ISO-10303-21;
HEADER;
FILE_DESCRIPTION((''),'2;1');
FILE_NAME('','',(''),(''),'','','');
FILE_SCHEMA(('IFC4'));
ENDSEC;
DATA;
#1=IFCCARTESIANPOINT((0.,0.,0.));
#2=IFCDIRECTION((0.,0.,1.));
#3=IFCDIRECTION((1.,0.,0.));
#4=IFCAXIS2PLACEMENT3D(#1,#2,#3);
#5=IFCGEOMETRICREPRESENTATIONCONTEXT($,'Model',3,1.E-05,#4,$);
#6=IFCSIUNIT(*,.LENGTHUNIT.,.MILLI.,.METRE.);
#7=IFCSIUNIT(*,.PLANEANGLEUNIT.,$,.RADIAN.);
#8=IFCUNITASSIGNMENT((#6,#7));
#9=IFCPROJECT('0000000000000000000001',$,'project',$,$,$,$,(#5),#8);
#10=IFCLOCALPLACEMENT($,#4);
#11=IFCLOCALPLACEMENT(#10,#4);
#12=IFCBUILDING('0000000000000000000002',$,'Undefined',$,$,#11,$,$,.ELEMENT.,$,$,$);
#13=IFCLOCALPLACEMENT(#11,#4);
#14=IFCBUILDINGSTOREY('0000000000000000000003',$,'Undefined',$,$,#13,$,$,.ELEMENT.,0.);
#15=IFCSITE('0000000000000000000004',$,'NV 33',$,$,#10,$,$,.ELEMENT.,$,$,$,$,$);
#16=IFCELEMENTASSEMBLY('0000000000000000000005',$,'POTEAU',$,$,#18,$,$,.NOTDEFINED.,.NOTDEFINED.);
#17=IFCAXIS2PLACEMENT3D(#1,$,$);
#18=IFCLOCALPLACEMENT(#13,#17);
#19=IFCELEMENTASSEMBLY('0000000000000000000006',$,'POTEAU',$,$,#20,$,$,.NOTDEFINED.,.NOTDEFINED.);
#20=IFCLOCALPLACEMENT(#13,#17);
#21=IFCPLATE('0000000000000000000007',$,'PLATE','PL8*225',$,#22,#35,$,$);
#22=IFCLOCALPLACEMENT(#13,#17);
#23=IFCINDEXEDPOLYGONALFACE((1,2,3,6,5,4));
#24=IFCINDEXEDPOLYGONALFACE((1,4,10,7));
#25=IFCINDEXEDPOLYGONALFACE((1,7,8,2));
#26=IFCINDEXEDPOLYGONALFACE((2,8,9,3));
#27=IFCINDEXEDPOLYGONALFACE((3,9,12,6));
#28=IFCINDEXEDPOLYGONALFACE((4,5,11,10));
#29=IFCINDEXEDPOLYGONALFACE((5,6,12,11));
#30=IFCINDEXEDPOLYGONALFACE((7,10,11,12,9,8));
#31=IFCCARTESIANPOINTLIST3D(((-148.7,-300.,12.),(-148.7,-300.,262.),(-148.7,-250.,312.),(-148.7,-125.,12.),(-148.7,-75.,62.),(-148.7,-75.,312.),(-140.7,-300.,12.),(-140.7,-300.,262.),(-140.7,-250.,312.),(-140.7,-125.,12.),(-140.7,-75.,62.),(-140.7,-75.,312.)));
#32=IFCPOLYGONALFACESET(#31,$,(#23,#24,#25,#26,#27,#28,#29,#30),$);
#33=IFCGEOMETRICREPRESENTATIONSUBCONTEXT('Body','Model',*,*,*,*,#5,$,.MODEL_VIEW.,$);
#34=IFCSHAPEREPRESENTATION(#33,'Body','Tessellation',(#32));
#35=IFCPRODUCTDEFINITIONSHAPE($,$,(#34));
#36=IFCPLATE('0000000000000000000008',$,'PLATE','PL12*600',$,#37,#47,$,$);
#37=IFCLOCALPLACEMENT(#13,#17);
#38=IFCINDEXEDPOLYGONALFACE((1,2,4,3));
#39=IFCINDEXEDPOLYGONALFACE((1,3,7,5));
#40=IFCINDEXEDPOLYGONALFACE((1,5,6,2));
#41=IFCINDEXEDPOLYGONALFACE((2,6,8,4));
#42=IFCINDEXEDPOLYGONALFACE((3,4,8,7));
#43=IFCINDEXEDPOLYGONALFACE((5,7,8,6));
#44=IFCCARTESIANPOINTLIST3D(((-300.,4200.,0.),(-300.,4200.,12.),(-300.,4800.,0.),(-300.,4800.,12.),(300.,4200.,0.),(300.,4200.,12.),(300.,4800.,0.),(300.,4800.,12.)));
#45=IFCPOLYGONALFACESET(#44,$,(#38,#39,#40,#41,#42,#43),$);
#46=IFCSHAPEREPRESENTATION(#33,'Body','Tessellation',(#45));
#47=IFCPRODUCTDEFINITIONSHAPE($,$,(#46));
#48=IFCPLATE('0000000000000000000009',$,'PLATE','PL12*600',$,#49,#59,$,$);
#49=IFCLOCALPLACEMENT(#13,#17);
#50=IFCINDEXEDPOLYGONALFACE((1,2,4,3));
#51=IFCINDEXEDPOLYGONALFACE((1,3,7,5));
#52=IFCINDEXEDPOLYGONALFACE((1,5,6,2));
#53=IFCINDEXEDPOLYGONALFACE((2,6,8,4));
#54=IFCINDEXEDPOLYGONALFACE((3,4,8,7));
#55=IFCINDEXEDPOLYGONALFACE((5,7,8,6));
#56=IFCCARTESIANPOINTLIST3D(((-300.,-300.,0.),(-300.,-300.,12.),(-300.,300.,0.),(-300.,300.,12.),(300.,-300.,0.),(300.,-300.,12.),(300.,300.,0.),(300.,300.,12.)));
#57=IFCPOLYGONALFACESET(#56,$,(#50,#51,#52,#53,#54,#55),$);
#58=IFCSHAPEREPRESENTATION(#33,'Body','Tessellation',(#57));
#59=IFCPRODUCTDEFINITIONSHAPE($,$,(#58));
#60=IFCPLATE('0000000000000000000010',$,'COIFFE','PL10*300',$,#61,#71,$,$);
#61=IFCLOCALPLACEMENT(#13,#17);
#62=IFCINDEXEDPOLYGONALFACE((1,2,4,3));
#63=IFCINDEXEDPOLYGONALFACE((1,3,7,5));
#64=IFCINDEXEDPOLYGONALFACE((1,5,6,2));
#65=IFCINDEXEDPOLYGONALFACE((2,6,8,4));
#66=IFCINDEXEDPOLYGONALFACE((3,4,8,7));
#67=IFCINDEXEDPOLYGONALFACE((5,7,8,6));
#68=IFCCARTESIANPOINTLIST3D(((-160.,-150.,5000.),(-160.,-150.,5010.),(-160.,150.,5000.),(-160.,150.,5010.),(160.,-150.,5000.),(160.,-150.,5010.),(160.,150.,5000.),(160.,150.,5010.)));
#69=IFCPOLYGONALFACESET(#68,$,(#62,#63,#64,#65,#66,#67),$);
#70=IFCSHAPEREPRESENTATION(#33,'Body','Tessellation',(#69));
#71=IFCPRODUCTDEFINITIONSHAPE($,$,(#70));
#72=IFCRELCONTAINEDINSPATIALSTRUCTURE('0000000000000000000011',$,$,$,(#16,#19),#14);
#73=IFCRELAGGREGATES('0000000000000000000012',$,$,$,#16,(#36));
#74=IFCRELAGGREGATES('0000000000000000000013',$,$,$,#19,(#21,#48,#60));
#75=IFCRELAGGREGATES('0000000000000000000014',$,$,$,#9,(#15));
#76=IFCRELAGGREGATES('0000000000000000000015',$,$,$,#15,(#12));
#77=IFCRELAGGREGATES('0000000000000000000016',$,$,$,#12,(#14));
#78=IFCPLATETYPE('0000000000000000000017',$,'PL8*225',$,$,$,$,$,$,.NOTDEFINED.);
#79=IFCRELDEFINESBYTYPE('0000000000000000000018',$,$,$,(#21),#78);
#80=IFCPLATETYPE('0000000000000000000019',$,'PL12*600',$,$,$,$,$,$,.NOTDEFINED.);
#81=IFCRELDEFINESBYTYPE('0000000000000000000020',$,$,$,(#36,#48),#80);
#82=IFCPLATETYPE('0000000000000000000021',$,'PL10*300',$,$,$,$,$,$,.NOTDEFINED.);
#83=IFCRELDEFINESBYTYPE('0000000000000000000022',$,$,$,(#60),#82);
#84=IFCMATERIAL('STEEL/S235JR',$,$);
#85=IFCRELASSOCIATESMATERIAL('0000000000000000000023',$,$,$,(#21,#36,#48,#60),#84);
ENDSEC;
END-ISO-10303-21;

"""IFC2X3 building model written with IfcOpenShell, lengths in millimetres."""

from ifc_helpers import new_model, si_unit, frame, origin_with_axes, place, context, subcontext, project, spatial, polyline, outline, extrude, material, type_object, element, aggregate, save


model = new_model("IFC2X3")

# Units and contexts
model_context = context("Model", 3, precision=1e-05, world=origin_with_axes())
body_context = subcontext(model_context, "Body", "Model", "MODEL_VIEW")
ifc_project = project(units=[si_unit("LENGTHUNIT", "METRE", prefix="MILLI"), si_unit("PLANEANGLEUNIT", "RADIAN")], contexts=[model_context])

# Site, building, storey
site_placement = place(None, origin_with_axes())
site = spatial("IfcSite", under=ifc_project, at=site_placement, Name="NV 33", CompositionType="ELEMENT")
building_placement = place(site_placement, origin_with_axes())
building = spatial("IfcBuilding", under=site, at=building_placement, Name="Undefined", CompositionType="ELEMENT")
storey_placement = place(building_placement, origin_with_axes())
storey = spatial("IfcBuildingStorey", under=building, at=storey_placement, Name="Undefined", CompositionType="ELEMENT", Elevation=0.0)

# Shared definitions
ifc_material_1 = material(Name="STEEL/S235JR")

# Element assemblies
assembly_1_placement = place(storey_placement, origin_with_axes())
assembly_1 = element("IfcElementAssembly", 1, at=assembly_1_placement, inside=storey, Name="POTEAU", AssemblyPlace="NOTDEFINED", PredefinedType="NOTDEFINED")
assembly_2_placement = place(storey_placement, origin_with_axes())
assembly_2 = element("IfcElementAssembly", 2, at=assembly_2_placement, inside=storey, Name="POTEAU", AssemblyPlace="NOTDEFINED", PredefinedType="NOTDEFINED")

# Plates
plate_type_1 = type_object("IfcPlateType", Name="PL8*225", PredefinedType="NOTDEFINED")
plate_1_placement = place(assembly_2_placement, frame((-144.7, -75.0, 12.0), z_axis=(-1.0, 0.0, 0.0), x_axis=(0.0, -1.0, 0.0)))
plate_1 = element("IfcPlate", 3, at=plate_1_placement, type_object=plate_type_1, material=ifc_material_1, Name="PLATE", Description="PL8*225", context=body_context, shape_type="SweptSolid", body=[
    extrude(outline(polyline([(0.0, 50.0), (50.0, 0.0), (225.0, 0.0), (225.0, 250.0), (175.0, 300.0), (0.0, 300.0), (0.0, 50.0)])), frame((0.0, 0.0, -4.0), z_axis=(0.0, 0.0, 1.0), x_axis=(1.0, 0.0, 0.0)), (0.0, 0.0, 1.0), 8.0),
])
plate_type_2 = type_object("IfcPlateType", Name="PL12*600", PredefinedType="NOTDEFINED")
plate_2_placement = place(assembly_1_placement, frame((-300.0, 4200.0, 6.0), z_axis=(0.0, 0.0, 1.0), x_axis=(1.0, 0.0, 0.0)))
plate_2 = element("IfcPlate", 4, at=plate_2_placement, type_object=plate_type_2, material=ifc_material_1, Name="PLATE", Description="PL12*600", context=body_context, shape_type="SweptSolid", body=[
    extrude(outline(polyline([(0.0, 0.0), (600.0, 0.0), (600.0, 600.0), (0.0, 600.0), (0.0, 0.0)])), frame((0.0, 0.0, -6.0), z_axis=(0.0, 0.0, 1.0), x_axis=(1.0, 0.0, 0.0)), (0.0, 0.0, 1.0), 12.0),
])
plate_3_placement = place(assembly_2_placement, frame((-300.0, -300.0, 6.0), z_axis=(0.0, 0.0, 1.0), x_axis=(1.0, 0.0, 0.0)))
plate_3 = element("IfcPlate", 5, at=plate_3_placement, type_object=plate_type_2, material=ifc_material_1, Name="PLATE", Description="PL12*600", context=body_context, shape_type="SweptSolid", body=[
    extrude(outline(polyline([(0.0, 0.0), (600.0, 0.0), (600.0, 600.0), (0.0, 600.0), (0.0, 0.0)])), frame((0.0, 0.0, -6.0), z_axis=(0.0, 0.0, 1.0), x_axis=(1.0, 0.0, 0.0)), (0.0, 0.0, 1.0), 12.0),
])
plate_type_3 = type_object("IfcPlateType", Name="PL10*300", PredefinedType="NOTDEFINED")
plate_4_placement = place(assembly_2_placement, frame((-160.0, 150.0, 5005.0), z_axis=(0.0, 0.0, 1.0), x_axis=(0.0, -1.0, 0.0)))
plate_4 = element("IfcPlate", 6, at=plate_4_placement, type_object=plate_type_3, material=ifc_material_1, Name="COIFFE", Description="PL10*300", context=body_context, shape_type="SweptSolid", body=[
    extrude(outline(polyline([(0.0, 0.0), (300.0, 0.0), (300.0, 320.0), (0.0, 320.0), (0.0, 0.0)])), frame((0.0, 0.0, -5.0), z_axis=(0.0, 0.0, 1.0), x_axis=(1.0, 0.0, 0.0)), (0.0, 0.0, 1.0), 10.0),
])

aggregate(assembly_1, [plate_2])
aggregate(assembly_2, [plate_1, plate_3, plate_4])

save(model, "model.ifc")
